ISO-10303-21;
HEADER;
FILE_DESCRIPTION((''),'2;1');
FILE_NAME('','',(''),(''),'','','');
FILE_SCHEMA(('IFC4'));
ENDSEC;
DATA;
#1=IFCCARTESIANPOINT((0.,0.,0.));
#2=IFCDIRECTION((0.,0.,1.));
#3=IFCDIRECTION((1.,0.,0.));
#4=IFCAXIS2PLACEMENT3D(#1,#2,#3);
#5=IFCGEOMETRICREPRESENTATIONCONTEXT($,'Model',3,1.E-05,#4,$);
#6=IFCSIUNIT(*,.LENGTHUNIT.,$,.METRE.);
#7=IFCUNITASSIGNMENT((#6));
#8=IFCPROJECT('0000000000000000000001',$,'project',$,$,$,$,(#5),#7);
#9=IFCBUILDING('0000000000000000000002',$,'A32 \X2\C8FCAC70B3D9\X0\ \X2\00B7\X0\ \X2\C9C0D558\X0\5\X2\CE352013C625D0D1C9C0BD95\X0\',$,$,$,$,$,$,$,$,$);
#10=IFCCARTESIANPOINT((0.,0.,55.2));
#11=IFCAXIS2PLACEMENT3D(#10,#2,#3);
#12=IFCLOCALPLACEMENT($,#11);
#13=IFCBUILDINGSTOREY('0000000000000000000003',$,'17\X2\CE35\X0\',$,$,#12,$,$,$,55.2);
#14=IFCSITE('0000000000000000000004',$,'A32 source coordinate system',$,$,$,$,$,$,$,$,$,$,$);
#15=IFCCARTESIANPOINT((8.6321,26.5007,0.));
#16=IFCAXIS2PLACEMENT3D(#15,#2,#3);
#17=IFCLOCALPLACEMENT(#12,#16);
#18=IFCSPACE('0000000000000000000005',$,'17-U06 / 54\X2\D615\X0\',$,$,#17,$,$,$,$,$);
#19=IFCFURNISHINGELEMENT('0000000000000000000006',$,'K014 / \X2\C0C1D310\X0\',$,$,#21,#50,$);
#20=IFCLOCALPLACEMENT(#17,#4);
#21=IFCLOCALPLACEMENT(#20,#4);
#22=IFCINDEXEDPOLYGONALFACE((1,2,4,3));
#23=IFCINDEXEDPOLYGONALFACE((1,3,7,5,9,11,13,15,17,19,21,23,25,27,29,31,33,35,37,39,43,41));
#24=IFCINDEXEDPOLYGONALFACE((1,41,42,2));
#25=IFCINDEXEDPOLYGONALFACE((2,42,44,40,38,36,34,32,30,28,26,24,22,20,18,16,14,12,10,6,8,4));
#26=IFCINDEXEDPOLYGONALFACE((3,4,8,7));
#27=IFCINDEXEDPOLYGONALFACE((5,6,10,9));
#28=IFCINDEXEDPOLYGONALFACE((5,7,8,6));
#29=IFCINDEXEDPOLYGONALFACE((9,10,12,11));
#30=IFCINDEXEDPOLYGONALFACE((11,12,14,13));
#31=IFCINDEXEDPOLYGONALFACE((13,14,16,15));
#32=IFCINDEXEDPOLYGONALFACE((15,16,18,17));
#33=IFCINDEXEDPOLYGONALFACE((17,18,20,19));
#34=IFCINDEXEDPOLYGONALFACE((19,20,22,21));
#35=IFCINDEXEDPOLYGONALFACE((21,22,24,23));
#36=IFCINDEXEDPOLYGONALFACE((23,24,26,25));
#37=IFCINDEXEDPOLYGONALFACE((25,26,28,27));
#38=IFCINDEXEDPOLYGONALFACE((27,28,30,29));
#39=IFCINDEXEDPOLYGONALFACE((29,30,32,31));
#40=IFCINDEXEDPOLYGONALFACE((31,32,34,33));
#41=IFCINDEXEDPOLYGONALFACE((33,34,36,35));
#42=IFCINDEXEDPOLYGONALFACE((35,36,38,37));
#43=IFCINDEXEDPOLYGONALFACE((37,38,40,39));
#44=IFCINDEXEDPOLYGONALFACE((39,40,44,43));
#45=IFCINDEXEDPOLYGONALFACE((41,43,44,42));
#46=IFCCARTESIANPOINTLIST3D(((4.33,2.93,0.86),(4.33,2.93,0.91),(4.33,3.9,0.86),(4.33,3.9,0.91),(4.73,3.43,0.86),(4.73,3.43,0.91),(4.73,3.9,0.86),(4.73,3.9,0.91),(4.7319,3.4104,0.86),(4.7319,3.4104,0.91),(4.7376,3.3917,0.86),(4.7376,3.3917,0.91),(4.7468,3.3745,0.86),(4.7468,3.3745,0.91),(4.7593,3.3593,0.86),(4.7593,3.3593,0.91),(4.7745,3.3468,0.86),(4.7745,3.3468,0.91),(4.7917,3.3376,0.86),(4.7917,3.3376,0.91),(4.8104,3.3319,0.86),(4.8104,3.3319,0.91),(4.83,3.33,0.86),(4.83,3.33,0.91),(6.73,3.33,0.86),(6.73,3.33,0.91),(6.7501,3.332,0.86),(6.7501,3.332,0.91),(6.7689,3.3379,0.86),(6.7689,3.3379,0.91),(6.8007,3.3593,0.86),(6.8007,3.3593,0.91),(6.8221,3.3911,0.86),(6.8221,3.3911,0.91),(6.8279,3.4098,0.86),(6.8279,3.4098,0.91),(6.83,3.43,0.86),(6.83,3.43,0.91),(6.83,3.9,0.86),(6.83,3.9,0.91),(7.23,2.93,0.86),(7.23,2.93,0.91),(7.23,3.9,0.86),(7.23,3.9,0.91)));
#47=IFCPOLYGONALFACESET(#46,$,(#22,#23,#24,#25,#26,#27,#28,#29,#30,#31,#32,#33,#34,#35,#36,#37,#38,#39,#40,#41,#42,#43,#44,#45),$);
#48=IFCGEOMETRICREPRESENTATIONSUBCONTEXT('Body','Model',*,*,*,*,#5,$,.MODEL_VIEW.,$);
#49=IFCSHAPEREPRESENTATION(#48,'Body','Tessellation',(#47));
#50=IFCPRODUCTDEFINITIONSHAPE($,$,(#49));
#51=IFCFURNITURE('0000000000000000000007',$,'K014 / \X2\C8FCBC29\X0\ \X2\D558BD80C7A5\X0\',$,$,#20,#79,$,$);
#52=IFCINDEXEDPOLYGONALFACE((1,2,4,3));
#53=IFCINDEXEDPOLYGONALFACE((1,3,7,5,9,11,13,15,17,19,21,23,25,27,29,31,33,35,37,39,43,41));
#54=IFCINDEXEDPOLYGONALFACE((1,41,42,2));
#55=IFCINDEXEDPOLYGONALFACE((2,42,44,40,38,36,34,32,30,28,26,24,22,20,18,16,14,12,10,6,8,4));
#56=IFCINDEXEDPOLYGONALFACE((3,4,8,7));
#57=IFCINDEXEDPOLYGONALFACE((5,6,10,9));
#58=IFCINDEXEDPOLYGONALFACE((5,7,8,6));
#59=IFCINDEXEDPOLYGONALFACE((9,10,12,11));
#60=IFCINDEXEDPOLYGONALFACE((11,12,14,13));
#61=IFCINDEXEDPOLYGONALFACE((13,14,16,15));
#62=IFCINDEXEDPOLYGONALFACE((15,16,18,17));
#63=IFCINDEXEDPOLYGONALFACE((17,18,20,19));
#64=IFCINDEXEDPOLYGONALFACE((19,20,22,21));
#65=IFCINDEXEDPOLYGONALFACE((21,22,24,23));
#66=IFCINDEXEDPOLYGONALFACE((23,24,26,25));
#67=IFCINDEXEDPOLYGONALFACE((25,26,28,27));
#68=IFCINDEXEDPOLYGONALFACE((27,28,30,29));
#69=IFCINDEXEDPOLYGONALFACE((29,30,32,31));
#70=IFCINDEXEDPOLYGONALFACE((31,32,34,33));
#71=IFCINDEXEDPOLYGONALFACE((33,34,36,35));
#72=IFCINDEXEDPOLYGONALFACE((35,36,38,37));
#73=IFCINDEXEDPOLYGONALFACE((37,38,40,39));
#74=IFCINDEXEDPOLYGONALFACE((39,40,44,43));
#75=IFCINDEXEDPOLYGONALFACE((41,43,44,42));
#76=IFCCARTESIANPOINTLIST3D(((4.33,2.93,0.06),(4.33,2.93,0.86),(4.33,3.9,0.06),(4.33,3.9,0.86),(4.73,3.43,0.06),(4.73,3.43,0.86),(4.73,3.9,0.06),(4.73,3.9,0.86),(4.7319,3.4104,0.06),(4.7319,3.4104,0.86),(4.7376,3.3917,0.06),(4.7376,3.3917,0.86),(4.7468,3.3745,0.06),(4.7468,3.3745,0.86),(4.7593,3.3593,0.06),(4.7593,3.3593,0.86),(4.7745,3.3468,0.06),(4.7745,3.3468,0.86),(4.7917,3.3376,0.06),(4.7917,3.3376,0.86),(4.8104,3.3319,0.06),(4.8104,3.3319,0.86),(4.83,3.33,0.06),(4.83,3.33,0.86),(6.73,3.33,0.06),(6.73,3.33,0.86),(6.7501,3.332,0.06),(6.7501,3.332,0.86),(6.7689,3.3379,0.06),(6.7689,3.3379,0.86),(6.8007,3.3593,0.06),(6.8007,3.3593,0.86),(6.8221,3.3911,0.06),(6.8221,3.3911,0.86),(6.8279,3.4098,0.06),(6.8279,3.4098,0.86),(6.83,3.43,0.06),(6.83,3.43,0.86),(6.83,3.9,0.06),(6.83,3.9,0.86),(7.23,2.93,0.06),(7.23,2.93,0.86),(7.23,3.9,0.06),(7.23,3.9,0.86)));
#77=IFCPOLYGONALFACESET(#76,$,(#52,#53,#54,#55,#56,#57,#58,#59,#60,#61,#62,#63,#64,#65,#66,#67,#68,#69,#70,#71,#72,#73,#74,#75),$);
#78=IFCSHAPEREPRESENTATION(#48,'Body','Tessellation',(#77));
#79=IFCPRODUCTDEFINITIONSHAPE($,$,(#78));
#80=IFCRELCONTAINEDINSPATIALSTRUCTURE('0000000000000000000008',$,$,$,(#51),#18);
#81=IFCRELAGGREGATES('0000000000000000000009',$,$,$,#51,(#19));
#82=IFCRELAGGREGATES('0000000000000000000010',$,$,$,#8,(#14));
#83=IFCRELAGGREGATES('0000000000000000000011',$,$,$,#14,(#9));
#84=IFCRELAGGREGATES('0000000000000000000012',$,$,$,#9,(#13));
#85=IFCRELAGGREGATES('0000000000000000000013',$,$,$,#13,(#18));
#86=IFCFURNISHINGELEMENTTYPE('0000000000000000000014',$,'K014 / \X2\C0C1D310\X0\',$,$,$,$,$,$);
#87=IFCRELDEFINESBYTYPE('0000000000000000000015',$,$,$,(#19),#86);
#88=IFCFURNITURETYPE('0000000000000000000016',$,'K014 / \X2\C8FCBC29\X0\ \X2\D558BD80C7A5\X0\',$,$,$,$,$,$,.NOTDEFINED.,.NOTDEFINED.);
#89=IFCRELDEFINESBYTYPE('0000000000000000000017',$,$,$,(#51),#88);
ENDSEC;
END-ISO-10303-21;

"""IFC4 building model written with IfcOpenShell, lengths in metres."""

from ifc_helpers import new_model, si_unit, frame, origin, origin_with_axes, place, context, subcontext, project, spatial, polyline, outline, extrude, source, transform, mapped, type_object, type_shapes, element, aggregate, save


model = new_model("IFC4")

# Units and contexts
model_context = context("Model", 3, precision=1e-05, world=origin_with_axes())
body_context = subcontext(model_context, "Body", "Model", "MODEL_VIEW")
ifc_project = project(units=[si_unit("LENGTHUNIT", "METRE")], contexts=[model_context])

# Site, building, storey, space
site = spatial("IfcSite", under=ifc_project, Name="A32 source coordinate system")
building = spatial("IfcBuilding", under=site, Name="A32 주거동 · 지하5층–옥탑지붕")
storey_placement = place(None, frame((0.0, 0.0, 55.2), z_axis=(0.0, 0.0, 1.0), x_axis=(1.0, 0.0, 0.0)))
storey = spatial("IfcBuildingStorey", under=building, at=storey_placement, Name="17층", Elevation=55.2)
space_placement = place(storey_placement, frame((8.6321, 26.5007, 0.0), z_axis=(0.0, 0.0, 1.0), x_axis=(1.0, 0.0, 0.0)))
space = spatial("IfcSpace", under=storey, at=space_placement, Name="17-U06 / 54형")

# Furnishing element
furnishing_element_type_1 = type_object("IfcFurnishingElementType", Name="K014 / 상판")
shared_shape_1 = source(origin(), body_context, "Body", "SweptSolid", [
    extrude(outline(polyline([(4.33, 2.93), (4.33, 3.9), (4.73, 3.9), (4.73, 3.43), (4.7319, 3.4104), (4.7376, 3.3917), (4.7468, 3.3745), (4.7593, 3.3593), (4.7745, 3.3468), (4.7917, 3.3376), (4.8104, 3.3319), (4.83, 3.33), (6.73, 3.33), (6.7501, 3.332), (6.7689, 3.3379), (6.8007, 3.3593), (6.8221, 3.3911), (6.8279, 3.4098), (6.83, 3.43), (6.83, 3.9), (7.23, 3.9), (7.23, 2.93), (4.33, 2.93)])), frame((0.0, 0.0, 0.86)), (0.0, 0.0, 1.0), 0.05),
])
type_shapes(furnishing_element_type_1, [shared_shape_1])
furniture_1_placement = place(space_placement, origin_with_axes())
furnishing_1_placement = place(furniture_1_placement, origin_with_axes())
furnishing_1 = element("IfcFurnishingElement", 1, at=furnishing_1_placement, type_object=furnishing_element_type_1, Name="K014 / 상판", context=body_context, shape_type="MappedRepresentation", body=[
    mapped(shared_shape_1, transform((0.0, 0.0, 0.0), scale=1.0)),
])

# Furniture
furniture_type_1 = type_object("IfcFurnitureType", Name="K014 / 주방 하부장", AssemblyPlace="NOTDEFINED", PredefinedType="NOTDEFINED")
shared_shape_2 = source(origin(), body_context, "Body", "SweptSolid", [
    extrude(outline(polyline([(7.23, 2.93), (4.33, 2.93), (4.33, 3.9), (4.73, 3.9), (4.73, 3.43), (4.7319, 3.4104), (4.7376, 3.3917), (4.7468, 3.3745), (4.7593, 3.3593), (4.7745, 3.3468), (4.7917, 3.3376), (4.8104, 3.3319), (4.83, 3.33), (6.73, 3.33), (6.7501, 3.332), (6.7689, 3.3379), (6.8007, 3.3593), (6.8221, 3.3911), (6.8279, 3.4098), (6.83, 3.43), (6.83, 3.9), (7.23, 3.9), (7.23, 2.93)])), frame((0.0, 0.0, 0.06)), (0.0, 0.0, 1.0), 0.8),
])
type_shapes(furniture_type_1, [shared_shape_2])
furniture_1 = element("IfcFurniture", 2, at=furniture_1_placement, inside=space, type_object=furniture_type_1, Name="K014 / 주방 하부장", context=body_context, shape_type="MappedRepresentation", body=[
    mapped(shared_shape_2, transform((0.0, 0.0, 0.0), scale=1.0)),
])
aggregate(furniture_1, [furnishing_1])

save(model, "model.ifc")
